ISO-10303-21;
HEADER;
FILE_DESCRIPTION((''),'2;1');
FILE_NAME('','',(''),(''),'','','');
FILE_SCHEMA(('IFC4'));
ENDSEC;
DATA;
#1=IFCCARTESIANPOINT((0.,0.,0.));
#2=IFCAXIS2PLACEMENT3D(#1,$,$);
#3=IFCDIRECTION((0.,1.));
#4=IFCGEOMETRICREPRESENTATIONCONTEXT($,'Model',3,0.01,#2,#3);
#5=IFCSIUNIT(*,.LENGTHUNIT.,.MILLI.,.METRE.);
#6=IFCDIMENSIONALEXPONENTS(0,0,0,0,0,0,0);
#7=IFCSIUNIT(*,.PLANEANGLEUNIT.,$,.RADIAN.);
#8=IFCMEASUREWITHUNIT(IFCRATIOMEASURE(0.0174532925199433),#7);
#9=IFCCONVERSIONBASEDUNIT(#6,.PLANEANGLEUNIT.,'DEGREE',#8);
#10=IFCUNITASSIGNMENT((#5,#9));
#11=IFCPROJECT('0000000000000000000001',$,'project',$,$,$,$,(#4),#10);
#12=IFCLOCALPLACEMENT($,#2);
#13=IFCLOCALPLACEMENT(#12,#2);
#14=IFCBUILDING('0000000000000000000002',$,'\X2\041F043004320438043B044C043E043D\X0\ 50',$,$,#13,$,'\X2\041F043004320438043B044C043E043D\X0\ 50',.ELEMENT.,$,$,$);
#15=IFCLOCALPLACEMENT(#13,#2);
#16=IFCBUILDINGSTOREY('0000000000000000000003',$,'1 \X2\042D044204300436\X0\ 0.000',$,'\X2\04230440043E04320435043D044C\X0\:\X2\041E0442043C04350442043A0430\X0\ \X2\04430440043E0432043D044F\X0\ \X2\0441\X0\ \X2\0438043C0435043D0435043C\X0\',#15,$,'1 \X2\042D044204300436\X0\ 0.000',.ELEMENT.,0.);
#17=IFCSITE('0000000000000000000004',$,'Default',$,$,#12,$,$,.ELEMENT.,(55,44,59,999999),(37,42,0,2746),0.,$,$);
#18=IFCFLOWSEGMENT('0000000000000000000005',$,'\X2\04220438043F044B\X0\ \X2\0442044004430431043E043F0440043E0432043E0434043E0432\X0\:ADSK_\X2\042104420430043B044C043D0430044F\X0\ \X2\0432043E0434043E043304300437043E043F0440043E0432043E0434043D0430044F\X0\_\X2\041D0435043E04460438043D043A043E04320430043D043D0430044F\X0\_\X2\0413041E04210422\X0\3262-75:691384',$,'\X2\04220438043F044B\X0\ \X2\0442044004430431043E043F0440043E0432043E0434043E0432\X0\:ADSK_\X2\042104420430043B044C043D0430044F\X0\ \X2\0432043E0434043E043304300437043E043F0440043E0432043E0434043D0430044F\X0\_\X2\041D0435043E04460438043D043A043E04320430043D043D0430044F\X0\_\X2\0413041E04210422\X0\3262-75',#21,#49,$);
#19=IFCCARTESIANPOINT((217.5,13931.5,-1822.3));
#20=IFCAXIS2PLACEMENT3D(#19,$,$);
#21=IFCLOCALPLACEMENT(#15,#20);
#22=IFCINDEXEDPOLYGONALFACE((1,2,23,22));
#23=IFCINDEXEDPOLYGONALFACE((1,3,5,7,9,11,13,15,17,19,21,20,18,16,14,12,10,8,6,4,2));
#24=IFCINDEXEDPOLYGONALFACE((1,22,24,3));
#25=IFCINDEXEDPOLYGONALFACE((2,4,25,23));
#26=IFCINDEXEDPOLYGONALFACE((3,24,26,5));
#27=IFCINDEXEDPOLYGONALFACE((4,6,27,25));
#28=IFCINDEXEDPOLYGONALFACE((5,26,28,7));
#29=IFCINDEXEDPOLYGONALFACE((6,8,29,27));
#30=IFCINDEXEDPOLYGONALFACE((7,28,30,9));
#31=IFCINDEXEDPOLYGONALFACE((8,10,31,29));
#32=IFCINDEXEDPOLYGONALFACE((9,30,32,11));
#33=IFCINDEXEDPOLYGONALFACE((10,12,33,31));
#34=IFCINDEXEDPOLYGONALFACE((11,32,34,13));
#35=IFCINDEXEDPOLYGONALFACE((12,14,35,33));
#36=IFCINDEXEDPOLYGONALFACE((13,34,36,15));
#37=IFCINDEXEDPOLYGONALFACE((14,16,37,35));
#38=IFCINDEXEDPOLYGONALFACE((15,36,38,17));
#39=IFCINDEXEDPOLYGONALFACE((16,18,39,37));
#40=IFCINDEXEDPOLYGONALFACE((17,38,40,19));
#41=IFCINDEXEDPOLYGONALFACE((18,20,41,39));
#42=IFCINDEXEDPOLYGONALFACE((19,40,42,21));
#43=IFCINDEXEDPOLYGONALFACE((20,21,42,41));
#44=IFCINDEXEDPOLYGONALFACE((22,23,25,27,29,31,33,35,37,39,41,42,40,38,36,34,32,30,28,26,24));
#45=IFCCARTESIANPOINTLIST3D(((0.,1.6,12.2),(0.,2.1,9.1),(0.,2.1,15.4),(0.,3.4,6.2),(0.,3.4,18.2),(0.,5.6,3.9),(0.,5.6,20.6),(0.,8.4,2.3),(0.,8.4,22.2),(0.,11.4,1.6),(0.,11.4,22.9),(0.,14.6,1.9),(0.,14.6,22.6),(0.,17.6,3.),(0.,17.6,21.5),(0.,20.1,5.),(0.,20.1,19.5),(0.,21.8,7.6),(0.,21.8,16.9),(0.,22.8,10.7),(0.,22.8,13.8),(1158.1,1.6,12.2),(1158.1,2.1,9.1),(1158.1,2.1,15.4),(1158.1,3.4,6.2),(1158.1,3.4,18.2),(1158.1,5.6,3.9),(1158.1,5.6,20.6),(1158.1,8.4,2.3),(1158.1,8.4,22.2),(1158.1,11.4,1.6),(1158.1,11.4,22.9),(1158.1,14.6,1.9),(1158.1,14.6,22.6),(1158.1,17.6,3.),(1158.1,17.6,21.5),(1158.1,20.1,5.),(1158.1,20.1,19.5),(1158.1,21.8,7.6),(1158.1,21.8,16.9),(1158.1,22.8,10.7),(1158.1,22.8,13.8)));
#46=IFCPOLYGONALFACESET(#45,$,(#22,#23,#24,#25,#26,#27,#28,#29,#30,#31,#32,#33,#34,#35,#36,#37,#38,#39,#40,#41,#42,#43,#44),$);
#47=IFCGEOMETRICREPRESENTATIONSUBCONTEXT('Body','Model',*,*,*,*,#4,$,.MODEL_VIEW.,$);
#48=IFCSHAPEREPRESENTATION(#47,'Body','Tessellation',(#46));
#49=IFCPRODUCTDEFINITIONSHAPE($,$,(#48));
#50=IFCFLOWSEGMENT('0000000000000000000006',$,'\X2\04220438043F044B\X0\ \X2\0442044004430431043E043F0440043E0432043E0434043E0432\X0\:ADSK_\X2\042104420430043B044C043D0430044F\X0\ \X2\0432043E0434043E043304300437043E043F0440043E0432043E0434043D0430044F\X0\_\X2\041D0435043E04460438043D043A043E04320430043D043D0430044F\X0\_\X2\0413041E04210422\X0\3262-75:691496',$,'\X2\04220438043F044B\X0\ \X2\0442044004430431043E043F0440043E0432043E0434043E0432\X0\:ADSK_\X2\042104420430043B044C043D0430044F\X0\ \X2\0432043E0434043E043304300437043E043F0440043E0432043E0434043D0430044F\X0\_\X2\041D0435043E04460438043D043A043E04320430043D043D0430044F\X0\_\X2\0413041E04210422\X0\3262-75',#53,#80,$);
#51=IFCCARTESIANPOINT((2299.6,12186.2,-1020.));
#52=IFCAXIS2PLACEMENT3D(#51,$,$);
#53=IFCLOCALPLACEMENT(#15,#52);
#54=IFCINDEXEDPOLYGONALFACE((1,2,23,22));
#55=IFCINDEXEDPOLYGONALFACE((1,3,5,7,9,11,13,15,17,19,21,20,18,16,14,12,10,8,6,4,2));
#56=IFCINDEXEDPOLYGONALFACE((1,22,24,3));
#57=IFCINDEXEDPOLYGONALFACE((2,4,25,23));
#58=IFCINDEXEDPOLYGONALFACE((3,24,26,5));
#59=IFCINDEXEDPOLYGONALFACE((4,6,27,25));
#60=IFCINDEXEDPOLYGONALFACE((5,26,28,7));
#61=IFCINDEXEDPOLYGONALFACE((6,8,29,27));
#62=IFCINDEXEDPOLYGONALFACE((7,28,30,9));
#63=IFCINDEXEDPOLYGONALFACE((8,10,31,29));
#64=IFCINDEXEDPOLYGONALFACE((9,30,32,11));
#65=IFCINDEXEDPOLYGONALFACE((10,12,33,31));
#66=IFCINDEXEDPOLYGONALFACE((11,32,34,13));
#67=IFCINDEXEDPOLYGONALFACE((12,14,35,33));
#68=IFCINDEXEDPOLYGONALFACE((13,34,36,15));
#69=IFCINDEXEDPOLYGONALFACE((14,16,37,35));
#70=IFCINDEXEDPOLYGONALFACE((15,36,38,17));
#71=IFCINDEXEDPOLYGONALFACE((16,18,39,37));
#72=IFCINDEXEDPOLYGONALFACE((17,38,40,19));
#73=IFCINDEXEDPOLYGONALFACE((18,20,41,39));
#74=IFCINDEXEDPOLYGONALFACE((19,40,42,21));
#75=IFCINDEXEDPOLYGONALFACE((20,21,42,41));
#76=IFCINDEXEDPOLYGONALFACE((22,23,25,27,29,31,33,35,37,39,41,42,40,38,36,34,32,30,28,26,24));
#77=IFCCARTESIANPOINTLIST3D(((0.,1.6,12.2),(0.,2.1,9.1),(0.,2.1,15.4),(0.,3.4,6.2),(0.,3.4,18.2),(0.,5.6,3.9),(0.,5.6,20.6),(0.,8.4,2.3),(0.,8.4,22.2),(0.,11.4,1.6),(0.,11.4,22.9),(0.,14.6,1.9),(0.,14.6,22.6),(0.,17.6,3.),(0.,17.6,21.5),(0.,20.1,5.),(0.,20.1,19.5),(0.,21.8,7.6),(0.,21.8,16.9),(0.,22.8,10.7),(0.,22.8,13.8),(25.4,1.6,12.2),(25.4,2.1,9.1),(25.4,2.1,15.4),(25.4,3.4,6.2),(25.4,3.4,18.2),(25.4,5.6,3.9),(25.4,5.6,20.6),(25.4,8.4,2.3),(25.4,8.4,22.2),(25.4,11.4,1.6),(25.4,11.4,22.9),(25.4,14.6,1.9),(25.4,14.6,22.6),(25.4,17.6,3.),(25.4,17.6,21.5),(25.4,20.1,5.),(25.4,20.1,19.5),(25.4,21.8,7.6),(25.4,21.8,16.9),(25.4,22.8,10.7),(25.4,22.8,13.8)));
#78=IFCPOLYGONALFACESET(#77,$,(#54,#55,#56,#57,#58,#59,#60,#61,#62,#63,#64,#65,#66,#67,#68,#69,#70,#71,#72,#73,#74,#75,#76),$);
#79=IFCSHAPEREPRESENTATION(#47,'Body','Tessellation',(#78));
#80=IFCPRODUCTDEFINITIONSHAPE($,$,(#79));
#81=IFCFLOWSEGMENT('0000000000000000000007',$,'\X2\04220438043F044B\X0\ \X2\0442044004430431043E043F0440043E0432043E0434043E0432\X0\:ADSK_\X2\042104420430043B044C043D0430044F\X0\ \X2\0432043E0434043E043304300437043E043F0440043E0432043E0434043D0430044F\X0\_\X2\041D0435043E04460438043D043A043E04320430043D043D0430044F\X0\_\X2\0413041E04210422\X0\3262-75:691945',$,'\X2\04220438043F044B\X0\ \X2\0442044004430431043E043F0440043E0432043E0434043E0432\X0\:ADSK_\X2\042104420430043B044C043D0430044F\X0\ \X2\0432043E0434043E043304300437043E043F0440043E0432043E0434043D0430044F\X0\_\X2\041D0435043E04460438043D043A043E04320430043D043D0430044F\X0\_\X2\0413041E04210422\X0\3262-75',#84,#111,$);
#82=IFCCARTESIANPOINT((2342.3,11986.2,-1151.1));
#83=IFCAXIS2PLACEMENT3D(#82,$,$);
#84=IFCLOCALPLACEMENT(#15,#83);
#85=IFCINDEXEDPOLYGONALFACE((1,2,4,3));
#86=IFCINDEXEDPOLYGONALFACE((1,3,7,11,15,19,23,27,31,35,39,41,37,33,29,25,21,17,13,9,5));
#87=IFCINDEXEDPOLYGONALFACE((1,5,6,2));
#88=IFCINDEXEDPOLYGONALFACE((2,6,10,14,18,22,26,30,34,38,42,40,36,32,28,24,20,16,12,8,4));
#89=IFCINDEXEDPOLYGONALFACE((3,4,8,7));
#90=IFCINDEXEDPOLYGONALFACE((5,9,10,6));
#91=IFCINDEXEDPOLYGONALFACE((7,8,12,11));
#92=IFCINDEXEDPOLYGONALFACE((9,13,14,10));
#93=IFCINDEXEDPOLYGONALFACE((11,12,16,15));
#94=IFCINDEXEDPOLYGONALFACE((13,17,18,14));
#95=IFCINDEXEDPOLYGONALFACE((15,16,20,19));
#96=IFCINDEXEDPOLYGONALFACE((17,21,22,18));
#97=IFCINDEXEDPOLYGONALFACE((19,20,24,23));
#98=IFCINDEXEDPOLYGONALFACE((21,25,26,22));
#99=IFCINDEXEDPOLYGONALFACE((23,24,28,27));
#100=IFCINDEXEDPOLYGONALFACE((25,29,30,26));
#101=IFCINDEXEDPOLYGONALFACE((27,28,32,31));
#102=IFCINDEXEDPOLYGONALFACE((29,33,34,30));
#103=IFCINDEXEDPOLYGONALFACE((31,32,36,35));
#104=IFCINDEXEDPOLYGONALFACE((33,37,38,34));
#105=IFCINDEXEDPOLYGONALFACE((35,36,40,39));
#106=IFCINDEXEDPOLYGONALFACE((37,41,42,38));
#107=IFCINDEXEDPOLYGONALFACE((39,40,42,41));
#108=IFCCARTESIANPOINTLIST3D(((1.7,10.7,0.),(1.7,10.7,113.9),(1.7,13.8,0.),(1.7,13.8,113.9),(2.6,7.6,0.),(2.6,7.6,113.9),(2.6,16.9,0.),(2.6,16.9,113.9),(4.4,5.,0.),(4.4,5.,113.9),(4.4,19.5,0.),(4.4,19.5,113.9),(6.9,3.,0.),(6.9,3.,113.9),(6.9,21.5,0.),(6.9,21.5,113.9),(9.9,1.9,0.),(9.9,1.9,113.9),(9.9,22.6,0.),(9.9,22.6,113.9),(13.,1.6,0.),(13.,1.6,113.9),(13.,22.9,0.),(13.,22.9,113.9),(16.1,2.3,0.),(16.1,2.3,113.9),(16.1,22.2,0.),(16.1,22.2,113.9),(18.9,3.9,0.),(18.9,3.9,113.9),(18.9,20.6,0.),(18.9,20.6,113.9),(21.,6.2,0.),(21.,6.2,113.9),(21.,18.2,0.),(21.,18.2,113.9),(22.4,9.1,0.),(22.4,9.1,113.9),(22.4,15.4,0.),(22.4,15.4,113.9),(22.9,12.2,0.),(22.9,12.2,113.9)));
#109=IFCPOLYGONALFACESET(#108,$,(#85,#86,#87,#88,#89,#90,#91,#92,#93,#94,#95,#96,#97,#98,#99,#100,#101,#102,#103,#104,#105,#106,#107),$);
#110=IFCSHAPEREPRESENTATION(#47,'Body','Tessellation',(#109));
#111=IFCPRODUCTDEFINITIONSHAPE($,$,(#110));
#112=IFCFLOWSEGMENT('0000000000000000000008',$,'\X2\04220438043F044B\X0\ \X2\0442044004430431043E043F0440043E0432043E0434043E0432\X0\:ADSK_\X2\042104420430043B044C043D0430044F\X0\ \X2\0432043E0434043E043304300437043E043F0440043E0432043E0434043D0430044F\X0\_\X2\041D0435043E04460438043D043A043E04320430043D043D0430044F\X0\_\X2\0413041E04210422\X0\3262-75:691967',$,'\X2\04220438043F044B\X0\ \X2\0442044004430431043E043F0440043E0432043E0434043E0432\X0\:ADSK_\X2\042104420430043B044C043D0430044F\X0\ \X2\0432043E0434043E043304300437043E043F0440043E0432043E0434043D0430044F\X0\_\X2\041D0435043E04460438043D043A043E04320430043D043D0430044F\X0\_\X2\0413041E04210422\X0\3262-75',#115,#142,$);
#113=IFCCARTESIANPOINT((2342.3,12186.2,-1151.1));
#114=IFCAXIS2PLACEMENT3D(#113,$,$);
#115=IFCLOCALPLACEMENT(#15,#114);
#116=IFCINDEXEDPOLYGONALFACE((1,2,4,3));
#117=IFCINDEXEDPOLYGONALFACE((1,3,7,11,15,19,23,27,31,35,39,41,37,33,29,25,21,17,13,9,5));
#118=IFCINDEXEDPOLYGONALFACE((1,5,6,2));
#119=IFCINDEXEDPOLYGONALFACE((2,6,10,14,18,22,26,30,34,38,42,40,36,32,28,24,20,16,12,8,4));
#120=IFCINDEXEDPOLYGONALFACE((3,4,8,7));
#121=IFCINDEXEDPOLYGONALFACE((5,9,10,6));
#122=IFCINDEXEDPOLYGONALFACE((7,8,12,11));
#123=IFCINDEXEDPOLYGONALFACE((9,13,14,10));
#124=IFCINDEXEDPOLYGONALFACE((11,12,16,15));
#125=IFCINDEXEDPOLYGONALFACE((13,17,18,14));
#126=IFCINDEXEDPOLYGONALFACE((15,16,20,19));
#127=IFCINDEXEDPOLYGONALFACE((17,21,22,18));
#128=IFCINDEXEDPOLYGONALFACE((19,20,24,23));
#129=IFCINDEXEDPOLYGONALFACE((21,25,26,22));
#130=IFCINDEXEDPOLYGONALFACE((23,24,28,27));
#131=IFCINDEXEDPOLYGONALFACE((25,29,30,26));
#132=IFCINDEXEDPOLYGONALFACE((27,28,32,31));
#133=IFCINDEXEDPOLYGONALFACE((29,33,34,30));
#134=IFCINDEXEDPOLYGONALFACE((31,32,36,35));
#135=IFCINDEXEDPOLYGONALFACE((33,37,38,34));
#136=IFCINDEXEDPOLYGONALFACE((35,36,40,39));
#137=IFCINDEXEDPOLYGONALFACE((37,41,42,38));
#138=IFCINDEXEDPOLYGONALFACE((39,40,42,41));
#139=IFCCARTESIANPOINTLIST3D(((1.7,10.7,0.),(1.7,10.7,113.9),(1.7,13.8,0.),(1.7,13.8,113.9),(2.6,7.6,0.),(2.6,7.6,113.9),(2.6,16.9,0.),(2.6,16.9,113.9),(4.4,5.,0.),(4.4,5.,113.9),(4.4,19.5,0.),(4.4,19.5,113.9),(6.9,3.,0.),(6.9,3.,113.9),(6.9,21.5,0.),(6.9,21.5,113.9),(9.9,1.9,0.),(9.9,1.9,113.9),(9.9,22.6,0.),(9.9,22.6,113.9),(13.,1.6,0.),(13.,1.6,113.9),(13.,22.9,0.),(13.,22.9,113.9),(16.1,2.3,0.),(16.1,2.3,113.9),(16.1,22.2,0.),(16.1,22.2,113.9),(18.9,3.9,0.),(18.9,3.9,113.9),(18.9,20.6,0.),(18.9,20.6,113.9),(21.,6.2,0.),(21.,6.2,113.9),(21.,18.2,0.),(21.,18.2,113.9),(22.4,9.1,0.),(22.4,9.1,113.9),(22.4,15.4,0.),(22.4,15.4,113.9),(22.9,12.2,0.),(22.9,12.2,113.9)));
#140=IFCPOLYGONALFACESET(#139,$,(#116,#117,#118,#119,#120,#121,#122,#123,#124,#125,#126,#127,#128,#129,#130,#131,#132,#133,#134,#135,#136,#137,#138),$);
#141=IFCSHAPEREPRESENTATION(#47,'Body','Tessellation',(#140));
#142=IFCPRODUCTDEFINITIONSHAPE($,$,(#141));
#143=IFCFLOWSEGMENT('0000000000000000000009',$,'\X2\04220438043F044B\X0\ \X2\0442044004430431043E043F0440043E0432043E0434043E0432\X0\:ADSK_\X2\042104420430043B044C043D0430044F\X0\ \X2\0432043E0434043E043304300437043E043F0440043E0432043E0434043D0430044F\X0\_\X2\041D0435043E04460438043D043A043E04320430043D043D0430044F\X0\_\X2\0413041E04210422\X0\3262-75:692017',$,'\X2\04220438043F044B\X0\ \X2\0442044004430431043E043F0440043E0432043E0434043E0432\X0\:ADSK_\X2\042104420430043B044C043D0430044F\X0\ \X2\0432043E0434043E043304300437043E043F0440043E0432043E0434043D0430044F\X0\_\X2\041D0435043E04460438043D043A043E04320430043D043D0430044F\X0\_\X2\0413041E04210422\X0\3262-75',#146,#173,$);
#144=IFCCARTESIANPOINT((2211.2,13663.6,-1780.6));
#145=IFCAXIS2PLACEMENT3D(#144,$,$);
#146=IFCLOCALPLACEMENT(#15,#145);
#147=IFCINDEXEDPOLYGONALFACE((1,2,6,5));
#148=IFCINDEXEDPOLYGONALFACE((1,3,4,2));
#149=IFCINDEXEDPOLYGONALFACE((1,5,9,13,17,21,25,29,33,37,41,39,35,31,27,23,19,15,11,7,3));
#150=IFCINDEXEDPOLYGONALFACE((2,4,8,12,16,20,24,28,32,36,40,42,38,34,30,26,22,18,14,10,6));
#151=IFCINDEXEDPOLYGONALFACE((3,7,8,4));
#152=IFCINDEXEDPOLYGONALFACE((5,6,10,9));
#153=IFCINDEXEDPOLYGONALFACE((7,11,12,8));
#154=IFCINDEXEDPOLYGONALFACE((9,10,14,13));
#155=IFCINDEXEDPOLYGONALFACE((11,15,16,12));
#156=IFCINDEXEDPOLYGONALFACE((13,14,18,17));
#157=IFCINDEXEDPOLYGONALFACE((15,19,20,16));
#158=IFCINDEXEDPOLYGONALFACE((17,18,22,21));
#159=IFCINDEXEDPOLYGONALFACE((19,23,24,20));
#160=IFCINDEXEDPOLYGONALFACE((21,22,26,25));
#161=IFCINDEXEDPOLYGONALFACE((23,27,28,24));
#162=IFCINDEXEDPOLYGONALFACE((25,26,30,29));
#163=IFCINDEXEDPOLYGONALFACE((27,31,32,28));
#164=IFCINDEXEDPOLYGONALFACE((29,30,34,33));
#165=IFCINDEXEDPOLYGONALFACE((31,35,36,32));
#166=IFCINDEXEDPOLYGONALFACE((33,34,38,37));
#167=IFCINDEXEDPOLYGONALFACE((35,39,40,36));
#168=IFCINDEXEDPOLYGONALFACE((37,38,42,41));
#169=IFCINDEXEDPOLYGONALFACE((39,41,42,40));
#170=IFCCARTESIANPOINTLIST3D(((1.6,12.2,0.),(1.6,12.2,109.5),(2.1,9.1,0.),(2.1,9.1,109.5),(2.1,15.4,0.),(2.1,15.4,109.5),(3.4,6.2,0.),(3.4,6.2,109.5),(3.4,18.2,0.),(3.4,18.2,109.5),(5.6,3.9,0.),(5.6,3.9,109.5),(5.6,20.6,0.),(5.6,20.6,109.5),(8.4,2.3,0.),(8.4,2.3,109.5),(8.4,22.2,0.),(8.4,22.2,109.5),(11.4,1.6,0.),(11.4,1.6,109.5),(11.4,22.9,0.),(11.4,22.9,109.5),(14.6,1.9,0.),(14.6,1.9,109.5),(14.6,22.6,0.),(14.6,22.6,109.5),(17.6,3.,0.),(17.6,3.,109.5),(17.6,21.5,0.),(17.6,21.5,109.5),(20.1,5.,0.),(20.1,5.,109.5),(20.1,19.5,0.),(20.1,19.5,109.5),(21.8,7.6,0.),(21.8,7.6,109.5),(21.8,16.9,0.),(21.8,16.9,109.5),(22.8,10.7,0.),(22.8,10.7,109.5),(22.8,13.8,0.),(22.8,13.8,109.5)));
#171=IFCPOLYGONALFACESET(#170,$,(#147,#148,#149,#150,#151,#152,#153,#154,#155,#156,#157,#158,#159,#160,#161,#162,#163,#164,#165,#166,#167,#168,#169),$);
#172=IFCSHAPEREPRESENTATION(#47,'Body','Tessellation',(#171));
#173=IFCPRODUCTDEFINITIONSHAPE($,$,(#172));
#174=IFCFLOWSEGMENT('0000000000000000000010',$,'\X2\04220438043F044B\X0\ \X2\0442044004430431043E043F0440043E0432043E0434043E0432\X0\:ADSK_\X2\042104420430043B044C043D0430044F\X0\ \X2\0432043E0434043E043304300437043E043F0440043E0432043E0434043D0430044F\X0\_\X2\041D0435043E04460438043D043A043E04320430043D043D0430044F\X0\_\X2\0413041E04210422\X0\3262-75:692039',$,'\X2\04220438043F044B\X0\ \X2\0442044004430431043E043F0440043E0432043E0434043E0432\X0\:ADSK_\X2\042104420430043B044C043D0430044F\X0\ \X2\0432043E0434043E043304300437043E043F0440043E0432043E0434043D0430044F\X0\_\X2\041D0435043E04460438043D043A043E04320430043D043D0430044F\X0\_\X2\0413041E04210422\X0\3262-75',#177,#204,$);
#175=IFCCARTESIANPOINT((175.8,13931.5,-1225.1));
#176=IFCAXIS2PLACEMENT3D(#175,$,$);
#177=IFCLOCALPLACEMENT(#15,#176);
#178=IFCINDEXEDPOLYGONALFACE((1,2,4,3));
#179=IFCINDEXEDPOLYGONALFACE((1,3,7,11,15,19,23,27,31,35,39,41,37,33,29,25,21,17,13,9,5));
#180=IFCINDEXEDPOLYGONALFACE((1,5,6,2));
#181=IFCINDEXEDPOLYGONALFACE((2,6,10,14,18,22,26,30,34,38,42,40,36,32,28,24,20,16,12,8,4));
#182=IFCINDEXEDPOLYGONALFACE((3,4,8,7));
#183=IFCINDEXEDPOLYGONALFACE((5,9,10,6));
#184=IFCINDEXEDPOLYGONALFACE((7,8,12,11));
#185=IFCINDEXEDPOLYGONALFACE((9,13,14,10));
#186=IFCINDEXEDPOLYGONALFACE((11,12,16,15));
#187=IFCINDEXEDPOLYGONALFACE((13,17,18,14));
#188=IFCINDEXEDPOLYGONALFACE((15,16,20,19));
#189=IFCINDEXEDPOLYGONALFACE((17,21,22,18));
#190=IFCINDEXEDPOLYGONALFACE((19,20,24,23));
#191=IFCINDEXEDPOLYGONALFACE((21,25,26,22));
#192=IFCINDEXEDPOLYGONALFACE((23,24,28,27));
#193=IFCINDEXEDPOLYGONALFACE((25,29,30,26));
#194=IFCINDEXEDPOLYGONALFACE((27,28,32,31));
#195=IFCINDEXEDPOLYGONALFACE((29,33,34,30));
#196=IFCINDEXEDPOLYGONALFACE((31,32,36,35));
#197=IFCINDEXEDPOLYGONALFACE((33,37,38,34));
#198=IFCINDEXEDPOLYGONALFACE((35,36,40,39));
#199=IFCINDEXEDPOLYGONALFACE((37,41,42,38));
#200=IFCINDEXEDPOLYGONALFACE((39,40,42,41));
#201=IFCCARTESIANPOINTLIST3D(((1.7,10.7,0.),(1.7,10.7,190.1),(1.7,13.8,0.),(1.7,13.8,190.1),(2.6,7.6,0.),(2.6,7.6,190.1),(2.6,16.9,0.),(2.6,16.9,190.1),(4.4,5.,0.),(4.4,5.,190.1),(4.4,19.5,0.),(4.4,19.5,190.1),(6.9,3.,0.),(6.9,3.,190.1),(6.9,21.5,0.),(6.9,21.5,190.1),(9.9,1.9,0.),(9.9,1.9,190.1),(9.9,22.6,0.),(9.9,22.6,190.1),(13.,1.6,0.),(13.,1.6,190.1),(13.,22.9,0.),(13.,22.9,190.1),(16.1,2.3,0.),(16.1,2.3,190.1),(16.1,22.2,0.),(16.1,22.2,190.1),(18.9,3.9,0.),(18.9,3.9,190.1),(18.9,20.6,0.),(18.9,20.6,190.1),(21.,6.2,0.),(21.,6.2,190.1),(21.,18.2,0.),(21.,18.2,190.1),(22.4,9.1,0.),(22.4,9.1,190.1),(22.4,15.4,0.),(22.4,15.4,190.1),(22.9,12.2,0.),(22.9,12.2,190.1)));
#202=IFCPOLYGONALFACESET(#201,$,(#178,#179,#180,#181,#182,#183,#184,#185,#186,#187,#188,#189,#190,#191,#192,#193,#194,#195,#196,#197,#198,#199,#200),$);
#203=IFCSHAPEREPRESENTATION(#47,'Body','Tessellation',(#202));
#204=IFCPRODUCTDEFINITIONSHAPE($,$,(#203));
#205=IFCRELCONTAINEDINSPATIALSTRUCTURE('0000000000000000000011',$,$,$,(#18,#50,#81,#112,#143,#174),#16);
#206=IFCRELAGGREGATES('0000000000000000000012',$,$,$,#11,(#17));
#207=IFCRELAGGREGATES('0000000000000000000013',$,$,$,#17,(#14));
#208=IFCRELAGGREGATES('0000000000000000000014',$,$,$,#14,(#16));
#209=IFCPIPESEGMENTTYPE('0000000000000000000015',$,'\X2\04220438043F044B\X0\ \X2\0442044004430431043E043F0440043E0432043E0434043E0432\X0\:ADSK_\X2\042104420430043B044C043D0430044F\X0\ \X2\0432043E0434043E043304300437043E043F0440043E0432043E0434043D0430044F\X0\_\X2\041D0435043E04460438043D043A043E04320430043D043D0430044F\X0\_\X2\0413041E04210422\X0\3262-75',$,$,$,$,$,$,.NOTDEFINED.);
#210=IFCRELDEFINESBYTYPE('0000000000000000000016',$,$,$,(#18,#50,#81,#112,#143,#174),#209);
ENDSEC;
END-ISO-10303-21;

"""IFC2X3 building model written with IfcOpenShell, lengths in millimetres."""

from ifc_helpers import new_model, entity, si_unit, converted_unit, direction, frame, frame_2d, origin, origin_2d_with_axis, place, context, subcontext, project, spatial, circle, extrude, type_object, element, save


model = new_model("IFC2X3")

# Units and contexts
model_context = context("Model", 3, precision=0.01, world=origin(), true_north=direction((0.0, 1.0)))
body_context = subcontext(model_context, "Body", "Model", "MODEL_VIEW")
ifc_project = project(units=[si_unit("LENGTHUNIT", "METRE", prefix="MILLI"), converted_unit("PLANEANGLEUNIT", "DEGREE", entity("IfcRatioMeasure", 0.0174532925199433), si_unit("PLANEANGLEUNIT", "RADIAN"), dimensions=[0, 0, 0, 0, 0, 0, 0])], contexts=[model_context])

# Site, building, storey
site_placement = place(None, origin())
site = spatial("IfcSite", under=ifc_project, at=site_placement, Name="Default", CompositionType="ELEMENT", RefLatitude=(55, 44, 59, 999999), RefLongitude=(37, 42, 0, 2746), RefElevation=0.0)
building_placement = place(site_placement, origin())
building = spatial("IfcBuilding", under=site, at=building_placement, Name="Павильон 50", LongName="Павильон 50", CompositionType="ELEMENT")
storey_placement = place(building_placement, origin())
storey = spatial("IfcBuildingStorey", under=building, at=storey_placement, Name="1 Этаж 0.000", ObjectType="Уровень:Отметка уровня с именем", LongName="1 Этаж 0.000", CompositionType="ELEMENT", Elevation=0.0)

# Flow segments
pipe_segment_type = type_object("IfcPipeSegmentType", Name="Типы трубопроводов:ADSK_Стальная водогазопроводная_Неоцинкованная_ГОСТ3262-75", PredefinedType="NOTDEFINED")
flow_segment_1_placement = place(storey_placement, frame((217.5, 13931.5, -1822.3)))
element("IfcFlowSegment", 1, at=flow_segment_1_placement, inside=storey, type_object=pipe_segment_type, Name="Типы трубопроводов:ADSK_Стальная водогазопроводная_Неоцинкованная_ГОСТ3262-75:691384", ObjectType="Типы трубопроводов:ADSK_Стальная водогазопроводная_Неоцинкованная_ГОСТ3262-75", context=body_context, shape_type="SweptSolid", body=[
    extrude(circle(Radius=10.7, at=origin_2d_with_axis()), frame((0.0, 12.2, 12.2), z_axis=(1.0, 0.0, 0.0), x_axis=(0.0, -1.0, 0.0)), (0.0, 0.0, 1.0), 1158.1),
])
flow_segment_2_placement = place(storey_placement, frame((2299.6, 12186.2, -1020.0)))
element("IfcFlowSegment", 2, at=flow_segment_2_placement, inside=storey, type_object=pipe_segment_type, Name="Типы трубопроводов:ADSK_Стальная водогазопроводная_Неоцинкованная_ГОСТ3262-75:691496", ObjectType="Типы трубопроводов:ADSK_Стальная водогазопроводная_Неоцинкованная_ГОСТ3262-75", context=body_context, shape_type="SweptSolid", body=[
    extrude(circle(Radius=10.7, at=origin_2d_with_axis()), frame((0.0, 12.2, 12.2), z_axis=(1.0, 0.0, 0.0), x_axis=(0.0, -1.0, 0.0)), (0.0, 0.0, 1.0), 25.4),
])
flow_segment_3_placement = place(storey_placement, frame((2342.3, 11986.2, -1151.1)))
element("IfcFlowSegment", 3, at=flow_segment_3_placement, inside=storey, type_object=pipe_segment_type, Name="Типы трубопроводов:ADSK_Стальная водогазопроводная_Неоцинкованная_ГОСТ3262-75:691945", ObjectType="Типы трубопроводов:ADSK_Стальная водогазопроводная_Неоцинкованная_ГОСТ3262-75", context=body_context, shape_type="SweptSolid", body=[
    extrude(circle(Radius=10.7, at=frame_2d((0.0, 0.0), x_axis=(1.0, 0.0))), frame((12.2, 12.2, 0.0)), (0.0, 0.0, 1.0), 113.9),
])
flow_segment_4_placement = place(storey_placement, frame((2342.3, 12186.2, -1151.1)))
element("IfcFlowSegment", 4, at=flow_segment_4_placement, inside=storey, type_object=pipe_segment_type, Name="Типы трубопроводов:ADSK_Стальная водогазопроводная_Неоцинкованная_ГОСТ3262-75:691967", ObjectType="Типы трубопроводов:ADSK_Стальная водогазопроводная_Неоцинкованная_ГОСТ3262-75", context=body_context, shape_type="SweptSolid", body=[
    extrude(circle(Radius=10.7, at=origin_2d_with_axis()), frame((12.2, 12.2, 0.0)), (0.0, 0.0, 1.0), 113.9),
])
flow_segment_5_placement = place(storey_placement, frame((2211.2, 13663.6, -1780.6)))
element("IfcFlowSegment", 5, at=flow_segment_5_placement, inside=storey, type_object=pipe_segment_type, Name="Типы трубопроводов:ADSK_Стальная водогазопроводная_Неоцинкованная_ГОСТ3262-75:692017", ObjectType="Типы трубопроводов:ADSK_Стальная водогазопроводная_Неоцинкованная_ГОСТ3262-75", context=body_context, shape_type="SweptSolid", body=[
    extrude(circle(Radius=10.7, at=frame_2d((0.0, 0.0), x_axis=(1.0, 0.0))), frame((12.2, 12.2, 0.0), z_axis=(0.0, 0.0, 1.0), x_axis=(-1.0, 0.0, 0.0)), (0.0, 0.0, 1.0), 109.5),
])
flow_segment_6_placement = place(storey_placement, frame((175.8, 13931.5, -1225.1)))
element("IfcFlowSegment", 6, at=flow_segment_6_placement, inside=storey, type_object=pipe_segment_type, Name="Типы трубопроводов:ADSK_Стальная водогазопроводная_Неоцинкованная_ГОСТ3262-75:692039", ObjectType="Типы трубопроводов:ADSK_Стальная водогазопроводная_Неоцинкованная_ГОСТ3262-75", context=body_context, shape_type="SweptSolid", body=[
    extrude(circle(Radius=10.7, at=frame_2d((0.0, 0.0), x_axis=(1.0, 0.0))), frame((12.2, 12.2, 0.0)), (0.0, 0.0, 1.0), 190.1),
])

save(model, "model.ifc")
